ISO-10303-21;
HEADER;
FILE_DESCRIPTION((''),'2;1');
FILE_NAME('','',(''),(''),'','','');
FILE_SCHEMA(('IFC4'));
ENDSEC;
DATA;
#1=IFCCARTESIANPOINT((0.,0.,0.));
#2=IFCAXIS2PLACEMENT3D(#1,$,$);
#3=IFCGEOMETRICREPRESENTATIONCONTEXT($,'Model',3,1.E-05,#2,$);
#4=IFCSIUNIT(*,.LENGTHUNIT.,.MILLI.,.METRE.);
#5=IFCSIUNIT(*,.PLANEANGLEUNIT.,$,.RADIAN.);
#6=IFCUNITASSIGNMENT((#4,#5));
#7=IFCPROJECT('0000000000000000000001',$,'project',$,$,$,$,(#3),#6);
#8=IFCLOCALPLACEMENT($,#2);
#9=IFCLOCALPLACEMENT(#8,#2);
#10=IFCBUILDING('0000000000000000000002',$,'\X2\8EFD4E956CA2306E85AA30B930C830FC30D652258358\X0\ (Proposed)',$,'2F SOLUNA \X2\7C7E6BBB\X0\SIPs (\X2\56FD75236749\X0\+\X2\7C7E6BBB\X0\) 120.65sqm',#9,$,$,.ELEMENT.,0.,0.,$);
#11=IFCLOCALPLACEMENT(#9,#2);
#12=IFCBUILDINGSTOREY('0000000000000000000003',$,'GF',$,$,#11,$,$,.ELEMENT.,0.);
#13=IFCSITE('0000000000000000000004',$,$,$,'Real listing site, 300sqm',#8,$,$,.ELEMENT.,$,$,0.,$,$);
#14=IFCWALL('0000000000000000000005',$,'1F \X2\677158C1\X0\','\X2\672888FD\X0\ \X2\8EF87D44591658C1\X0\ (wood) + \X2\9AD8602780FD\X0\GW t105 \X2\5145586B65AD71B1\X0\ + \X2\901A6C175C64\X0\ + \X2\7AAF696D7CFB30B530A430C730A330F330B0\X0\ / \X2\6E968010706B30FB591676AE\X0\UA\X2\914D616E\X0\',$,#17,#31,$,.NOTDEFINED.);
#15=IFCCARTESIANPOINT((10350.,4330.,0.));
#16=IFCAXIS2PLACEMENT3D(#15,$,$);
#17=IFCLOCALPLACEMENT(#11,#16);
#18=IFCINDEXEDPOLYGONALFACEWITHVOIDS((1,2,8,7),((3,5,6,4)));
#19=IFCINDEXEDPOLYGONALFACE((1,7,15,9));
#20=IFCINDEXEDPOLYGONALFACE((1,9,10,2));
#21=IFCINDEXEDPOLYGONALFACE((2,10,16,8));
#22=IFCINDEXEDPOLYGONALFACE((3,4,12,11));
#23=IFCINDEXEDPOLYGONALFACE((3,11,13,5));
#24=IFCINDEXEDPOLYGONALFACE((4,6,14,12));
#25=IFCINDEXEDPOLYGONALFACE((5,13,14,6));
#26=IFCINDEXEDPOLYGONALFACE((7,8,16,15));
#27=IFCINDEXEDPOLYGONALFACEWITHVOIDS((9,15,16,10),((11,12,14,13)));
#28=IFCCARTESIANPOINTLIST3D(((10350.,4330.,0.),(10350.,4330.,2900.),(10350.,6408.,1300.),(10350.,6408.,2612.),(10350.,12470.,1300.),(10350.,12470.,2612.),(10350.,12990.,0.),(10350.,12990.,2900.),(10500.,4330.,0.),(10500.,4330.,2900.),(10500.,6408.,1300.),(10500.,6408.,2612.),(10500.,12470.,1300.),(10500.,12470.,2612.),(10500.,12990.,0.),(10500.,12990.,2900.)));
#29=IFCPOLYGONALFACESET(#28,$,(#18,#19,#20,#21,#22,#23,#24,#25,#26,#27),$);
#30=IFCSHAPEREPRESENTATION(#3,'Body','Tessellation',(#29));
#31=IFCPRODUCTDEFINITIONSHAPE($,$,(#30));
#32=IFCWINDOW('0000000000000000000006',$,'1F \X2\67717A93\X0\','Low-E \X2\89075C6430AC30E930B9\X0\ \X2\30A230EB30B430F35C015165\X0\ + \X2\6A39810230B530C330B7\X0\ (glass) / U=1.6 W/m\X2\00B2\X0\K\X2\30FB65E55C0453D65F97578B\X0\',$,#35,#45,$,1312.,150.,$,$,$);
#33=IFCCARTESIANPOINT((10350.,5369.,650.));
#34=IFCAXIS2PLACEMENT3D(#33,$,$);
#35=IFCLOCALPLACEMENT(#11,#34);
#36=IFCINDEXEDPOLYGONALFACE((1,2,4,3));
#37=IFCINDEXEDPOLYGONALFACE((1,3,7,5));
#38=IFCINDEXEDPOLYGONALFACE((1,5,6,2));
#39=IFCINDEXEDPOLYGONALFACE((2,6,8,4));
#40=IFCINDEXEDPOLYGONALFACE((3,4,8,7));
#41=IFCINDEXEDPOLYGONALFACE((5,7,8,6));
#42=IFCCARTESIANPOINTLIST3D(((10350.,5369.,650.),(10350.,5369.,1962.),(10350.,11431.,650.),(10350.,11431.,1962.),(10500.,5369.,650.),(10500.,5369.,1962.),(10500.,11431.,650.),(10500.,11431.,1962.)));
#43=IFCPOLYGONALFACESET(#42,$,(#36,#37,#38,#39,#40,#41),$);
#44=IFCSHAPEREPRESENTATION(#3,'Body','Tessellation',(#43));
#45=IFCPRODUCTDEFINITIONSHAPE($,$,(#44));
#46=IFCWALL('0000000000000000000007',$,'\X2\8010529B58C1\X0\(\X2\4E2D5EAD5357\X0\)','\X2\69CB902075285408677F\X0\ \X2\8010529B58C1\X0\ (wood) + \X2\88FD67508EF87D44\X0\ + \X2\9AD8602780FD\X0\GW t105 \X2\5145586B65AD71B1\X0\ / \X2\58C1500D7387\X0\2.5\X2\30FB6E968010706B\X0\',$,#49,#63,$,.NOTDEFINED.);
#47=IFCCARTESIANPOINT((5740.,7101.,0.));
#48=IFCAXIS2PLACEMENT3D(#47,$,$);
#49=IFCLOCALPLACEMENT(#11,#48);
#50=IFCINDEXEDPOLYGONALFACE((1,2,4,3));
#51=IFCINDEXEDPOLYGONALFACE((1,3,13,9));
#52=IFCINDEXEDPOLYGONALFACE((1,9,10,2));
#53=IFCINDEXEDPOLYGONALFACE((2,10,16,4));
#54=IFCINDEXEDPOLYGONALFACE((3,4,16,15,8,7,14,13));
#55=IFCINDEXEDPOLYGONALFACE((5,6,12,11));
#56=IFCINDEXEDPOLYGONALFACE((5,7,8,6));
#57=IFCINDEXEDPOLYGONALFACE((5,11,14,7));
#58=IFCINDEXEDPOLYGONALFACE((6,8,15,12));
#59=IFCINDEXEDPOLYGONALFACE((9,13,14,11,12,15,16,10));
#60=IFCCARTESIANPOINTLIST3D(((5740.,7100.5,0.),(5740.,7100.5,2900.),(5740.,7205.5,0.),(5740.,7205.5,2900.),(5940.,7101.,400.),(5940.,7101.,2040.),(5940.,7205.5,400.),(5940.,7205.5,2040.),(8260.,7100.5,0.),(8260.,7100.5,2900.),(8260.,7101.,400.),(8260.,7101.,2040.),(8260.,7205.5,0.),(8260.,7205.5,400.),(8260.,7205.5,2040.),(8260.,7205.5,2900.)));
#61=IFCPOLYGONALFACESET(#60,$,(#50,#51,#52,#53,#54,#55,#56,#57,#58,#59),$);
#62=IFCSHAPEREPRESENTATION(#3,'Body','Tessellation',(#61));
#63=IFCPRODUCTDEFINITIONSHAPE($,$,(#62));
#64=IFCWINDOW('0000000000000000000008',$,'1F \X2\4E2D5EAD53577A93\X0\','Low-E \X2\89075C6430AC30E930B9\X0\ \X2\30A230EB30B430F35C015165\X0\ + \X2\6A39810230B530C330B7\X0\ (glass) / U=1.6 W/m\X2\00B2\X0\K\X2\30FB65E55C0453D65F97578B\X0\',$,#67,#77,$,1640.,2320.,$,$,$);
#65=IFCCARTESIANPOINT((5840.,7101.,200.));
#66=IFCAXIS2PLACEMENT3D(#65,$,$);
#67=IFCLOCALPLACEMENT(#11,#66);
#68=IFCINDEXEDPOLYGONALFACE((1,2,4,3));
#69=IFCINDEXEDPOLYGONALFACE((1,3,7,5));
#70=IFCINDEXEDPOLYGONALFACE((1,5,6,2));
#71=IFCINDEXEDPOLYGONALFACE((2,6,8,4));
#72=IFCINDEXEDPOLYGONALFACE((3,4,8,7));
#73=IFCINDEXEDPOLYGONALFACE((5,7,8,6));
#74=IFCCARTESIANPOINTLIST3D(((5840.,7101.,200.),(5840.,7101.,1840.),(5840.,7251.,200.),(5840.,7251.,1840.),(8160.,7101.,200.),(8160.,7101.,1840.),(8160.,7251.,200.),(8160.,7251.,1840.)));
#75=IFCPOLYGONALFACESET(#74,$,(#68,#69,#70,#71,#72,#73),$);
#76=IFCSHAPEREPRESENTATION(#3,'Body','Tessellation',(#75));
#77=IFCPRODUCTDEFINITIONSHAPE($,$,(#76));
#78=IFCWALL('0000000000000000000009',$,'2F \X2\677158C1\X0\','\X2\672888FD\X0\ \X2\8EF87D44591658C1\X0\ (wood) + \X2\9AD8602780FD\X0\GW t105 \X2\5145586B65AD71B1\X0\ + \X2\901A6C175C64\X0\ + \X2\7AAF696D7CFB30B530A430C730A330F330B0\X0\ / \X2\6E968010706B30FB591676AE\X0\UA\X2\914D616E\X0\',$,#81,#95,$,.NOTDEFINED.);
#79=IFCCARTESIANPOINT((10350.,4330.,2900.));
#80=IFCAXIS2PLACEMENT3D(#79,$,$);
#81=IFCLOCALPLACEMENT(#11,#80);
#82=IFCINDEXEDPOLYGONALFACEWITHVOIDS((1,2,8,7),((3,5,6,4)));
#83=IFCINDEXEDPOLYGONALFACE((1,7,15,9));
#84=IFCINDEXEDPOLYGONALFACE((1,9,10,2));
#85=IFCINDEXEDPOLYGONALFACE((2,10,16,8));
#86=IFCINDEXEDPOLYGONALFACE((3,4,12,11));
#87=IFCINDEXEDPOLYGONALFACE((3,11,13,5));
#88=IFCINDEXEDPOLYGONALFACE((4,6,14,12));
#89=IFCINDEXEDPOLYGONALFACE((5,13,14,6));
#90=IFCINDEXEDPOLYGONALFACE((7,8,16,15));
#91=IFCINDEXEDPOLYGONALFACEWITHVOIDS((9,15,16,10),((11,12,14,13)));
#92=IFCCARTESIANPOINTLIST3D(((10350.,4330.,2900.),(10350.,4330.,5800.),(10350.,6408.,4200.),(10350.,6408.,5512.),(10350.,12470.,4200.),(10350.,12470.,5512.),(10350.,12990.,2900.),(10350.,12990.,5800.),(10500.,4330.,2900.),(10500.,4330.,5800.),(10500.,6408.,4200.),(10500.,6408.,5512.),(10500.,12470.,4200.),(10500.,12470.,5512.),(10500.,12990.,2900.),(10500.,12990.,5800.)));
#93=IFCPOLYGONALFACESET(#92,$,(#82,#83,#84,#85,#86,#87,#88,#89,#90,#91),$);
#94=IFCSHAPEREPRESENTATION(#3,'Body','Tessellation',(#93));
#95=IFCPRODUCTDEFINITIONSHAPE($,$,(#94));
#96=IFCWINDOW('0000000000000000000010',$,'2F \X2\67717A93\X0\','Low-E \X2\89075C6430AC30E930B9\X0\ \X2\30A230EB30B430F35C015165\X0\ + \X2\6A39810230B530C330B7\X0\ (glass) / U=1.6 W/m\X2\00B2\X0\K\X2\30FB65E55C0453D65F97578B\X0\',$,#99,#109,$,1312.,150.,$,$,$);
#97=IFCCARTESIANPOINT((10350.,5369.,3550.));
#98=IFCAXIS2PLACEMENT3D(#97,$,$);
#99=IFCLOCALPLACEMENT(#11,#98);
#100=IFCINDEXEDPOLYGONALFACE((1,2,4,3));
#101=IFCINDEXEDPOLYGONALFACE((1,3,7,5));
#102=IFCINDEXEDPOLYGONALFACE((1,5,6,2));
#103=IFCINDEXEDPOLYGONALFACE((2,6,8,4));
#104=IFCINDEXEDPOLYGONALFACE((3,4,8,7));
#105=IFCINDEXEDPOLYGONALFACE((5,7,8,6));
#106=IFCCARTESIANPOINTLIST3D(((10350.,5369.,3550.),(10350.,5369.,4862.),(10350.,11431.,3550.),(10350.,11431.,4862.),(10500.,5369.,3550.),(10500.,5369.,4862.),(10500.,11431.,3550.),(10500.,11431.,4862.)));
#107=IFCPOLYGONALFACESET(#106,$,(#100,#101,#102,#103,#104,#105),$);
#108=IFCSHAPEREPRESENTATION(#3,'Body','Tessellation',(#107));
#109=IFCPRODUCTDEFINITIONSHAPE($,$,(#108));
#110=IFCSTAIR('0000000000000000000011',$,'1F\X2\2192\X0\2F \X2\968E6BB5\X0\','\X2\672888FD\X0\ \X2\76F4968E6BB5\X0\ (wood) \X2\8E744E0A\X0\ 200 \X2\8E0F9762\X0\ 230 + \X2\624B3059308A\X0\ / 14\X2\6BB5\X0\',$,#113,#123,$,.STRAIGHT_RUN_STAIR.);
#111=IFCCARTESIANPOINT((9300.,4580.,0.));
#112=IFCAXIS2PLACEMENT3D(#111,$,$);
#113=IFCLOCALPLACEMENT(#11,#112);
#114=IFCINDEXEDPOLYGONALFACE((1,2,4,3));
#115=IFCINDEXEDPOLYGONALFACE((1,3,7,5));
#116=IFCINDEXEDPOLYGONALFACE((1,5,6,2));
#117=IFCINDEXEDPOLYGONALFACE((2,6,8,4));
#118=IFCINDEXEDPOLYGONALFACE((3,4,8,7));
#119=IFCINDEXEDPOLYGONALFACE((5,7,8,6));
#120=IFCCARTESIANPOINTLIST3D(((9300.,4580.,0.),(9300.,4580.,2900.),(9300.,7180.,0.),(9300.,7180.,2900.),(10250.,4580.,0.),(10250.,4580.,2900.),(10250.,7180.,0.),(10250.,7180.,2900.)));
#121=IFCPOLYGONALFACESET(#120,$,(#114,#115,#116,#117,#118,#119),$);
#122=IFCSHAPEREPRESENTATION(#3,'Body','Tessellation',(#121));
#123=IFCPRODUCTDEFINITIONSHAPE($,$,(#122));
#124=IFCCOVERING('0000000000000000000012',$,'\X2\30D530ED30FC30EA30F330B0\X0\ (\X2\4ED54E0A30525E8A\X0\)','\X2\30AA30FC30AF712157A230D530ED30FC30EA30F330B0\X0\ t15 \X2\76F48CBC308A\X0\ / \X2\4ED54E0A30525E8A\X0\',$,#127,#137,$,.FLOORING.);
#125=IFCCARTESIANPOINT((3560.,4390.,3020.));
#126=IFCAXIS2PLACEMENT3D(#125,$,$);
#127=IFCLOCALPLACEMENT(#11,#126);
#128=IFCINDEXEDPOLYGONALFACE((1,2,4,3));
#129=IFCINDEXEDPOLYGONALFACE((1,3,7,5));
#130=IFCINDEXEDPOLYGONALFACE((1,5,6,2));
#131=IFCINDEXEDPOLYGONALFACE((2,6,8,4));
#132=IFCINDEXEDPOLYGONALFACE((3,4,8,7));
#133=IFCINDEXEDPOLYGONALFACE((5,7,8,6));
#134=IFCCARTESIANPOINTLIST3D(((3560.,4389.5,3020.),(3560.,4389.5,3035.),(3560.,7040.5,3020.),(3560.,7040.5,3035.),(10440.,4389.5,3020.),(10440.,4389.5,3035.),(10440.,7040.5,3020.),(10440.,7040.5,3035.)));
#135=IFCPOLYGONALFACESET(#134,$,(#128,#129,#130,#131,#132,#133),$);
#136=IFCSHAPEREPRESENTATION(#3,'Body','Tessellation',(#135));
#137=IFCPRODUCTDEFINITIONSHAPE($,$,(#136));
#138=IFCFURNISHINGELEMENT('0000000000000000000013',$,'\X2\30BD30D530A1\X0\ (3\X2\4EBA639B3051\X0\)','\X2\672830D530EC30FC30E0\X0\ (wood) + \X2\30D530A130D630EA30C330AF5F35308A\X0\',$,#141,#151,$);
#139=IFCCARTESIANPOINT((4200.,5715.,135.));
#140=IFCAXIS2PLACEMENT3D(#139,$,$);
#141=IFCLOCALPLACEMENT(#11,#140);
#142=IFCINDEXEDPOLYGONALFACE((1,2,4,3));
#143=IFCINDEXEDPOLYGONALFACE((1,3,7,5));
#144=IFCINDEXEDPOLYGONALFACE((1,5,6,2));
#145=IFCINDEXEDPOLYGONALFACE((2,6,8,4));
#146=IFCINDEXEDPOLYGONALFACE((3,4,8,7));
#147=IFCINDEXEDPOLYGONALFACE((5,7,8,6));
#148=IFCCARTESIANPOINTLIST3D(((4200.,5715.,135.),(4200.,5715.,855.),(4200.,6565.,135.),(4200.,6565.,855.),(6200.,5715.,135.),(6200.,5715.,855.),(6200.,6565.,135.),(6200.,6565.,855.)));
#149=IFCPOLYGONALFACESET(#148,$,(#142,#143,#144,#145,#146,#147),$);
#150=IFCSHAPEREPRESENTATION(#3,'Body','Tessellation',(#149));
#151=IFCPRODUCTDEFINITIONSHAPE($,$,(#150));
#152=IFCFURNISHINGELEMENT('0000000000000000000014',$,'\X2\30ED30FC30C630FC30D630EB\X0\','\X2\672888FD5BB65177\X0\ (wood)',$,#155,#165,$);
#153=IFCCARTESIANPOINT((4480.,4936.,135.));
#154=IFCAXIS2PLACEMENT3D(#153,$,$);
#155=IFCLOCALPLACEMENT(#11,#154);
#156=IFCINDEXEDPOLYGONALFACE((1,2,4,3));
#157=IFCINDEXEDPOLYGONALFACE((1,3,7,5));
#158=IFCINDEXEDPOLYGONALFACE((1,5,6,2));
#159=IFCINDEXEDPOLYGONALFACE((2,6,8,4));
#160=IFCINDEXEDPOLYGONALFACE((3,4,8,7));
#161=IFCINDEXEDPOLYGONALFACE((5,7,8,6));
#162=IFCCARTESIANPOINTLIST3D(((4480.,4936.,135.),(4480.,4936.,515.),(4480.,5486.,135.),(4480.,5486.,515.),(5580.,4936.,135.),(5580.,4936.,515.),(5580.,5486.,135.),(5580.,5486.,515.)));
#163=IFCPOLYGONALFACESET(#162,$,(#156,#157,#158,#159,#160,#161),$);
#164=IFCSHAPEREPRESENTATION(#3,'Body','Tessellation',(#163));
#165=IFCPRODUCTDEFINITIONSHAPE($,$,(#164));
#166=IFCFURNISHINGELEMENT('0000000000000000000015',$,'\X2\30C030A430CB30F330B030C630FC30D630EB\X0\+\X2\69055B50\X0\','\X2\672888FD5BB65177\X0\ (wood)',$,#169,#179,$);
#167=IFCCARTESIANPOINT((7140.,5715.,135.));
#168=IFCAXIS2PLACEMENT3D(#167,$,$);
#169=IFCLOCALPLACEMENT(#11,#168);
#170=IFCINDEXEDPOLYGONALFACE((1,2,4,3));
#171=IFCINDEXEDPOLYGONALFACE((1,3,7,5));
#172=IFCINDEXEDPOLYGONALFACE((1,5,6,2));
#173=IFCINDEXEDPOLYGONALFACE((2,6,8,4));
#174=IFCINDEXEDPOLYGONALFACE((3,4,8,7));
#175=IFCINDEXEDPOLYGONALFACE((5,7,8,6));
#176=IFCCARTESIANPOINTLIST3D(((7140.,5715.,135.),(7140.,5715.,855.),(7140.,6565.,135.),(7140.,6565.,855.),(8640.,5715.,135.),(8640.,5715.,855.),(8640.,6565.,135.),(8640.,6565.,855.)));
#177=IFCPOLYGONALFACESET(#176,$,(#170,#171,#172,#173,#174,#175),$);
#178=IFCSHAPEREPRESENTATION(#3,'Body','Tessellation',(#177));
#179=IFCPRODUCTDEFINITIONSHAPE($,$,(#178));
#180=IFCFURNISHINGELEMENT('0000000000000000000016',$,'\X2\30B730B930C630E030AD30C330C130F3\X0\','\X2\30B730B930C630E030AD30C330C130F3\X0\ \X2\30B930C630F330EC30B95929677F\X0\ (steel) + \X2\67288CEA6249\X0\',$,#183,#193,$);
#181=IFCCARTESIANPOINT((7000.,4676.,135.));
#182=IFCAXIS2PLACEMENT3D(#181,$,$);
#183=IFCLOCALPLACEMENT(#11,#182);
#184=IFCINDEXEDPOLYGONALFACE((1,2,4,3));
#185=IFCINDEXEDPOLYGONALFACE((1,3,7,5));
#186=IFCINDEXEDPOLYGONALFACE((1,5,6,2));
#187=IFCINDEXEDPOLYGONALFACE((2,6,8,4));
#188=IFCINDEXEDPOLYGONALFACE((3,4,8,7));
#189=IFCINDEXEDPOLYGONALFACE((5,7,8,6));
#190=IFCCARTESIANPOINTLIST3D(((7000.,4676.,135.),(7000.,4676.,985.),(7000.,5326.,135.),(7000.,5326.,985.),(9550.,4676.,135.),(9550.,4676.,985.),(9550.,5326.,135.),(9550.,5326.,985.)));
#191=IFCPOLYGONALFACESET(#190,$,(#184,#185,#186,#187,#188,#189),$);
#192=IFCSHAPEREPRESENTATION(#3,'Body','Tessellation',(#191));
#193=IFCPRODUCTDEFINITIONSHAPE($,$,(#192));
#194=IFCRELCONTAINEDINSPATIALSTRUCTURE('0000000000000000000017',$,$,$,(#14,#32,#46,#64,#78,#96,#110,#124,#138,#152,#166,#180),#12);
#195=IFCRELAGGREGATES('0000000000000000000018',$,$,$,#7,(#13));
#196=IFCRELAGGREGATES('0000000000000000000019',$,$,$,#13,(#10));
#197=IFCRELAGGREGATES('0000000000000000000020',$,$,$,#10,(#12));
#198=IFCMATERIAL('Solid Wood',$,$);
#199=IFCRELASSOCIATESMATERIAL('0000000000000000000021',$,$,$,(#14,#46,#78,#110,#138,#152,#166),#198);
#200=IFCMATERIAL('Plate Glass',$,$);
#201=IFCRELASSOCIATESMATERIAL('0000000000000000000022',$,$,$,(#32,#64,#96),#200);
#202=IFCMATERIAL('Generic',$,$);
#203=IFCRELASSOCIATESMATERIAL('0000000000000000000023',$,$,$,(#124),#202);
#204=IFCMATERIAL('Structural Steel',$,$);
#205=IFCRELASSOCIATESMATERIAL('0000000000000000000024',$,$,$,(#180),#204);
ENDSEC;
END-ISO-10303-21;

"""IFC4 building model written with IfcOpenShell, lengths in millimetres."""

from ifc_helpers import new_model, si_unit, frame, frame_2d, origin, place, context, project, spatial, rectangle, extrude, material, element, fill, save


model = new_model("IFC4")

# Units and contexts
model_context = context("Model", 3, precision=1e-05, world=origin())
ifc_project = project(units=[si_unit("LENGTHUNIT", "METRE", prefix="MILLI"), si_unit("PLANEANGLEUNIT", "RADIAN")], contexts=[model_context])

# Site, building, storey
site_placement = place(None, origin())
site = spatial("IfcSite", under=ifc_project, at=site_placement, ObjectType="Real listing site, 300sqm", CompositionType="ELEMENT", RefElevation=0.0)
building_placement = place(site_placement, origin())
building = spatial("IfcBuilding", under=site, at=building_placement, Name="軽井沢の薪ストーブ別荘 (Proposed)", ObjectType="2F SOLUNA 籾殻SIPs (国産杉+籾殻) 120.65sqm", CompositionType="ELEMENT", ElevationOfRefHeight=0.0, ElevationOfTerrain=0.0)
storey_placement = place(building_placement, origin())
storey = spatial("IfcBuildingStorey", under=building, at=storey_placement, Name="GF", CompositionType="ELEMENT", Elevation=0.0)

# Shared definitions
ifc_material_1 = material(Name="Solid Wood")

# Walls, openings, windows
wall_1_placement = place(storey_placement, frame((10350.0, 4330.0, 0.0)))
wall_1 = element("IfcWall", 1, at=wall_1_placement, inside=storey, material=ifc_material_1, Name="1F 東壁", Description="木製 軸組外壁 (wood) + 高性能GW t105 充填断熱 + 通気層 + 窯業系サイディング / 準耐火・外皮UA配慮", PredefinedType="NOTDEFINED", context=model_context, shape_type="SweptSolid", body=[
    extrude(rectangle(XDim=150.0, YDim=8660.0, at=frame_2d((75.0, 4330.0))), frame((10350.0, 4330.0, 0.0)), (0.0, 0.0, 1.0), 2900.0),
])
opening_1_placement = place(storey_placement, frame((10350.0, 5369.0, 650.0)))
opening_1 = element("IfcOpeningElement", 2, at=opening_1_placement, cuts=wall_1, PredefinedType="NOTDEFINED", context=model_context, shape_type="SweptSolid", body=[
    extrude(rectangle(XDim=150.0, YDim=6062.0, at=frame_2d((75.0, 3031.0))), frame((10350.0, 5369.0, 650.0)), (0.0, 0.0, 1.0), 1312.0),
])
ifc_material_2 = material(Name="Plate Glass")
window_1_placement = place(storey_placement, frame((10350.0, 5369.0, 650.0)))
window_1 = element("IfcWindow", 3, at=window_1_placement, inside=storey, material=ifc_material_2, Name="1F 東窓", Description="Low-E 複層ガラス アルゴン封入 + 樹脂サッシ (glass) / U=1.6 W/m²K・日射取得型", OverallHeight=1312.0, OverallWidth=150.0, context=model_context, shape_type="SweptSolid", body=[
    extrude(rectangle(XDim=150.0, YDim=6062.0, at=frame_2d((75.0, 3031.0))), frame((10350.0, 5369.0, 650.0)), (0.0, 0.0, 1.0), 1312.0),
])
fill(opening_1, window_1)
wall_2_placement = place(storey_placement, frame((5740.0, 7101.0, 0.0)))
wall_2 = element("IfcWall", 4, at=wall_2_placement, inside=storey, material=ifc_material_1, Name="耐力壁(中庭南)", Description="構造用合板 耐力壁 (wood) + 製材軸組 + 高性能GW t105 充填断熱 / 壁倍率2.5・準耐火", PredefinedType="NOTDEFINED", context=model_context, shape_type="SweptSolid", body=[
    extrude(rectangle(XDim=2520.0, YDim=105.0, at=frame_2d((1260.0, 52.0))), frame((5740.0, 7101.0, 0.0)), (0.0, 0.0, 1.0), 2900.0),
])
opening_2_placement = place(storey_placement, frame((5840.0, 7101.0, 200.0)))
opening_2 = element("IfcOpeningElement", 5, at=opening_2_placement, cuts=wall_2, PredefinedType="NOTDEFINED", context=model_context, shape_type="SweptSolid", body=[
    extrude(rectangle(XDim=2320.0, YDim=150.0, at=frame_2d((1160.0, 75.0))), frame((5840.0, 7101.0, 200.0)), (0.0, 0.0, 1.0), 1640.0),
])
window_2_placement = place(storey_placement, frame((5840.0, 7101.0, 200.0)))
window_2 = element("IfcWindow", 6, at=window_2_placement, inside=storey, material=ifc_material_2, Name="1F 中庭南窓", Description="Low-E 複層ガラス アルゴン封入 + 樹脂サッシ (glass) / U=1.6 W/m²K・日射取得型", OverallHeight=1640.0, OverallWidth=2320.0, context=model_context, shape_type="SweptSolid", body=[
    extrude(rectangle(XDim=2320.0, YDim=150.0, at=frame_2d((1160.0, 75.0))), frame((5840.0, 7101.0, 200.0)), (0.0, 0.0, 1.0), 1640.0),
])
fill(opening_2, window_2)

# Wall, opening, window
wall_3_placement = place(storey_placement, frame((10350.0, 4330.0, 2900.0)))
wall_3 = element("IfcWall", 7, at=wall_3_placement, inside=storey, material=ifc_material_1, Name="2F 東壁", Description="木製 軸組外壁 (wood) + 高性能GW t105 充填断熱 + 通気層 + 窯業系サイディング / 準耐火・外皮UA配慮", PredefinedType="NOTDEFINED", context=model_context, shape_type="SweptSolid", body=[
    extrude(rectangle(XDim=150.0, YDim=8660.0, at=frame_2d((75.0, 4330.0))), frame((10350.0, 4330.0, 2900.0)), (0.0, 0.0, 1.0), 2900.0),
])
opening_3_placement = place(storey_placement, frame((10350.0, 5369.0, 3550.0)))
opening_3 = element("IfcOpeningElement", 8, at=opening_3_placement, cuts=wall_3, PredefinedType="NOTDEFINED", context=model_context, shape_type="SweptSolid", body=[
    extrude(rectangle(XDim=150.0, YDim=6062.0, at=frame_2d((75.0, 3031.0))), frame((10350.0, 5369.0, 3550.0)), (0.0, 0.0, 1.0), 1312.0),
])
window_3_placement = place(storey_placement, frame((10350.0, 5369.0, 3550.0)))
window_3 = element("IfcWindow", 9, at=window_3_placement, inside=storey, material=ifc_material_2, Name="2F 東窓", Description="Low-E 複層ガラス アルゴン封入 + 樹脂サッシ (glass) / U=1.6 W/m²K・日射取得型", OverallHeight=1312.0, OverallWidth=150.0, context=model_context, shape_type="SweptSolid", body=[
    extrude(rectangle(XDim=150.0, YDim=6062.0, at=frame_2d((75.0, 3031.0))), frame((10350.0, 5369.0, 3550.0)), (0.0, 0.0, 1.0), 1312.0),
])
fill(opening_3, window_3)

# Stair
stair_placement = place(storey_placement, frame((9300.0, 4580.0, 0.0)))
element("IfcStair", 10, at=stair_placement, inside=storey, material=ifc_material_1, Name="1F→2F 階段", Description="木製 直階段 (wood) 蹴上 200 踏面 230 + 手すり / 14段", PredefinedType="STRAIGHT_RUN_STAIR", context=model_context, shape_type="SweptSolid", body=[
    extrude(rectangle(XDim=950.0, YDim=2600.0, at=frame_2d((475.0, 1300.0))), frame((9300.0, 4580.0, 0.0)), (0.0, 0.0, 1.0), 2900.0),
])

# Covering
ifc_material_3 = material(Name="Generic")
covering_placement = place(storey_placement, frame((3560.0, 4390.0, 3020.0)))
element("IfcCovering", 11, at=covering_placement, inside=storey, material=ifc_material_3, Name="フローリング (仕上げ床)", Description="オーク無垢フローリング t15 直貼り / 仕上げ床", PredefinedType="FLOORING", context=model_context, shape_type="SweptSolid", body=[
    extrude(rectangle(XDim=6880.0, YDim=2651.0, at=frame_2d((3440.0, 1325.0))), frame((3560.0, 4390.0, 3020.0)), (0.0, 0.0, 1.0), 15.0),
])

# Furnishing elements
furnishing_1_placement = place(storey_placement, frame((4200.0, 5715.0, 135.0)))
element("IfcFurnishingElement", 12, at=furnishing_1_placement, inside=storey, material=ifc_material_1, Name="ソファ (3人掛け)", Description="木フレーム (wood) + ファブリック張り", context=model_context, shape_type="SweptSolid", body=[
    extrude(rectangle(XDim=2000.0, YDim=850.0, at=frame_2d((1000.0, 425.0))), frame((4200.0, 5715.0, 135.0)), (0.0, 0.0, 1.0), 720.0),
])
furnishing_2_placement = place(storey_placement, frame((4480.0, 4936.0, 135.0)))
element("IfcFurnishingElement", 13, at=furnishing_2_placement, inside=storey, material=ifc_material_1, Name="ローテーブル", Description="木製家具 (wood)", context=model_context, shape_type="SweptSolid", body=[
    extrude(rectangle(XDim=1100.0, YDim=550.0, at=frame_2d((550.0, 275.0))), frame((4480.0, 4936.0, 135.0)), (0.0, 0.0, 1.0), 380.0),
])
furnishing_3_placement = place(storey_placement, frame((7140.0, 5715.0, 135.0)))
element("IfcFurnishingElement", 14, at=furnishing_3_placement, inside=storey, material=ifc_material_1, Name="ダイニングテーブル+椅子", Description="木製家具 (wood)", context=model_context, shape_type="SweptSolid", body=[
    extrude(rectangle(XDim=1500.0, YDim=850.0, at=frame_2d((750.0, 425.0))), frame((7140.0, 5715.0, 135.0)), (0.0, 0.0, 1.0), 720.0),
])
ifc_material_4 = material(Name="Structural Steel")
furnishing_4_placement = place(storey_placement, frame((7000.0, 4676.0, 135.0)))
element("IfcFurnishingElement", 15, at=furnishing_4_placement, inside=storey, material=ifc_material_4, Name="システムキッチン", Description="システムキッチン ステンレス天板 (steel) + 木質扉", context=model_context, shape_type="SweptSolid", body=[
    extrude(rectangle(XDim=2550.0, YDim=650.0, at=frame_2d((1275.0, 325.0))), frame((7000.0, 4676.0, 135.0)), (0.0, 0.0, 1.0), 850.0),
])

save(model, "model.ifc")
